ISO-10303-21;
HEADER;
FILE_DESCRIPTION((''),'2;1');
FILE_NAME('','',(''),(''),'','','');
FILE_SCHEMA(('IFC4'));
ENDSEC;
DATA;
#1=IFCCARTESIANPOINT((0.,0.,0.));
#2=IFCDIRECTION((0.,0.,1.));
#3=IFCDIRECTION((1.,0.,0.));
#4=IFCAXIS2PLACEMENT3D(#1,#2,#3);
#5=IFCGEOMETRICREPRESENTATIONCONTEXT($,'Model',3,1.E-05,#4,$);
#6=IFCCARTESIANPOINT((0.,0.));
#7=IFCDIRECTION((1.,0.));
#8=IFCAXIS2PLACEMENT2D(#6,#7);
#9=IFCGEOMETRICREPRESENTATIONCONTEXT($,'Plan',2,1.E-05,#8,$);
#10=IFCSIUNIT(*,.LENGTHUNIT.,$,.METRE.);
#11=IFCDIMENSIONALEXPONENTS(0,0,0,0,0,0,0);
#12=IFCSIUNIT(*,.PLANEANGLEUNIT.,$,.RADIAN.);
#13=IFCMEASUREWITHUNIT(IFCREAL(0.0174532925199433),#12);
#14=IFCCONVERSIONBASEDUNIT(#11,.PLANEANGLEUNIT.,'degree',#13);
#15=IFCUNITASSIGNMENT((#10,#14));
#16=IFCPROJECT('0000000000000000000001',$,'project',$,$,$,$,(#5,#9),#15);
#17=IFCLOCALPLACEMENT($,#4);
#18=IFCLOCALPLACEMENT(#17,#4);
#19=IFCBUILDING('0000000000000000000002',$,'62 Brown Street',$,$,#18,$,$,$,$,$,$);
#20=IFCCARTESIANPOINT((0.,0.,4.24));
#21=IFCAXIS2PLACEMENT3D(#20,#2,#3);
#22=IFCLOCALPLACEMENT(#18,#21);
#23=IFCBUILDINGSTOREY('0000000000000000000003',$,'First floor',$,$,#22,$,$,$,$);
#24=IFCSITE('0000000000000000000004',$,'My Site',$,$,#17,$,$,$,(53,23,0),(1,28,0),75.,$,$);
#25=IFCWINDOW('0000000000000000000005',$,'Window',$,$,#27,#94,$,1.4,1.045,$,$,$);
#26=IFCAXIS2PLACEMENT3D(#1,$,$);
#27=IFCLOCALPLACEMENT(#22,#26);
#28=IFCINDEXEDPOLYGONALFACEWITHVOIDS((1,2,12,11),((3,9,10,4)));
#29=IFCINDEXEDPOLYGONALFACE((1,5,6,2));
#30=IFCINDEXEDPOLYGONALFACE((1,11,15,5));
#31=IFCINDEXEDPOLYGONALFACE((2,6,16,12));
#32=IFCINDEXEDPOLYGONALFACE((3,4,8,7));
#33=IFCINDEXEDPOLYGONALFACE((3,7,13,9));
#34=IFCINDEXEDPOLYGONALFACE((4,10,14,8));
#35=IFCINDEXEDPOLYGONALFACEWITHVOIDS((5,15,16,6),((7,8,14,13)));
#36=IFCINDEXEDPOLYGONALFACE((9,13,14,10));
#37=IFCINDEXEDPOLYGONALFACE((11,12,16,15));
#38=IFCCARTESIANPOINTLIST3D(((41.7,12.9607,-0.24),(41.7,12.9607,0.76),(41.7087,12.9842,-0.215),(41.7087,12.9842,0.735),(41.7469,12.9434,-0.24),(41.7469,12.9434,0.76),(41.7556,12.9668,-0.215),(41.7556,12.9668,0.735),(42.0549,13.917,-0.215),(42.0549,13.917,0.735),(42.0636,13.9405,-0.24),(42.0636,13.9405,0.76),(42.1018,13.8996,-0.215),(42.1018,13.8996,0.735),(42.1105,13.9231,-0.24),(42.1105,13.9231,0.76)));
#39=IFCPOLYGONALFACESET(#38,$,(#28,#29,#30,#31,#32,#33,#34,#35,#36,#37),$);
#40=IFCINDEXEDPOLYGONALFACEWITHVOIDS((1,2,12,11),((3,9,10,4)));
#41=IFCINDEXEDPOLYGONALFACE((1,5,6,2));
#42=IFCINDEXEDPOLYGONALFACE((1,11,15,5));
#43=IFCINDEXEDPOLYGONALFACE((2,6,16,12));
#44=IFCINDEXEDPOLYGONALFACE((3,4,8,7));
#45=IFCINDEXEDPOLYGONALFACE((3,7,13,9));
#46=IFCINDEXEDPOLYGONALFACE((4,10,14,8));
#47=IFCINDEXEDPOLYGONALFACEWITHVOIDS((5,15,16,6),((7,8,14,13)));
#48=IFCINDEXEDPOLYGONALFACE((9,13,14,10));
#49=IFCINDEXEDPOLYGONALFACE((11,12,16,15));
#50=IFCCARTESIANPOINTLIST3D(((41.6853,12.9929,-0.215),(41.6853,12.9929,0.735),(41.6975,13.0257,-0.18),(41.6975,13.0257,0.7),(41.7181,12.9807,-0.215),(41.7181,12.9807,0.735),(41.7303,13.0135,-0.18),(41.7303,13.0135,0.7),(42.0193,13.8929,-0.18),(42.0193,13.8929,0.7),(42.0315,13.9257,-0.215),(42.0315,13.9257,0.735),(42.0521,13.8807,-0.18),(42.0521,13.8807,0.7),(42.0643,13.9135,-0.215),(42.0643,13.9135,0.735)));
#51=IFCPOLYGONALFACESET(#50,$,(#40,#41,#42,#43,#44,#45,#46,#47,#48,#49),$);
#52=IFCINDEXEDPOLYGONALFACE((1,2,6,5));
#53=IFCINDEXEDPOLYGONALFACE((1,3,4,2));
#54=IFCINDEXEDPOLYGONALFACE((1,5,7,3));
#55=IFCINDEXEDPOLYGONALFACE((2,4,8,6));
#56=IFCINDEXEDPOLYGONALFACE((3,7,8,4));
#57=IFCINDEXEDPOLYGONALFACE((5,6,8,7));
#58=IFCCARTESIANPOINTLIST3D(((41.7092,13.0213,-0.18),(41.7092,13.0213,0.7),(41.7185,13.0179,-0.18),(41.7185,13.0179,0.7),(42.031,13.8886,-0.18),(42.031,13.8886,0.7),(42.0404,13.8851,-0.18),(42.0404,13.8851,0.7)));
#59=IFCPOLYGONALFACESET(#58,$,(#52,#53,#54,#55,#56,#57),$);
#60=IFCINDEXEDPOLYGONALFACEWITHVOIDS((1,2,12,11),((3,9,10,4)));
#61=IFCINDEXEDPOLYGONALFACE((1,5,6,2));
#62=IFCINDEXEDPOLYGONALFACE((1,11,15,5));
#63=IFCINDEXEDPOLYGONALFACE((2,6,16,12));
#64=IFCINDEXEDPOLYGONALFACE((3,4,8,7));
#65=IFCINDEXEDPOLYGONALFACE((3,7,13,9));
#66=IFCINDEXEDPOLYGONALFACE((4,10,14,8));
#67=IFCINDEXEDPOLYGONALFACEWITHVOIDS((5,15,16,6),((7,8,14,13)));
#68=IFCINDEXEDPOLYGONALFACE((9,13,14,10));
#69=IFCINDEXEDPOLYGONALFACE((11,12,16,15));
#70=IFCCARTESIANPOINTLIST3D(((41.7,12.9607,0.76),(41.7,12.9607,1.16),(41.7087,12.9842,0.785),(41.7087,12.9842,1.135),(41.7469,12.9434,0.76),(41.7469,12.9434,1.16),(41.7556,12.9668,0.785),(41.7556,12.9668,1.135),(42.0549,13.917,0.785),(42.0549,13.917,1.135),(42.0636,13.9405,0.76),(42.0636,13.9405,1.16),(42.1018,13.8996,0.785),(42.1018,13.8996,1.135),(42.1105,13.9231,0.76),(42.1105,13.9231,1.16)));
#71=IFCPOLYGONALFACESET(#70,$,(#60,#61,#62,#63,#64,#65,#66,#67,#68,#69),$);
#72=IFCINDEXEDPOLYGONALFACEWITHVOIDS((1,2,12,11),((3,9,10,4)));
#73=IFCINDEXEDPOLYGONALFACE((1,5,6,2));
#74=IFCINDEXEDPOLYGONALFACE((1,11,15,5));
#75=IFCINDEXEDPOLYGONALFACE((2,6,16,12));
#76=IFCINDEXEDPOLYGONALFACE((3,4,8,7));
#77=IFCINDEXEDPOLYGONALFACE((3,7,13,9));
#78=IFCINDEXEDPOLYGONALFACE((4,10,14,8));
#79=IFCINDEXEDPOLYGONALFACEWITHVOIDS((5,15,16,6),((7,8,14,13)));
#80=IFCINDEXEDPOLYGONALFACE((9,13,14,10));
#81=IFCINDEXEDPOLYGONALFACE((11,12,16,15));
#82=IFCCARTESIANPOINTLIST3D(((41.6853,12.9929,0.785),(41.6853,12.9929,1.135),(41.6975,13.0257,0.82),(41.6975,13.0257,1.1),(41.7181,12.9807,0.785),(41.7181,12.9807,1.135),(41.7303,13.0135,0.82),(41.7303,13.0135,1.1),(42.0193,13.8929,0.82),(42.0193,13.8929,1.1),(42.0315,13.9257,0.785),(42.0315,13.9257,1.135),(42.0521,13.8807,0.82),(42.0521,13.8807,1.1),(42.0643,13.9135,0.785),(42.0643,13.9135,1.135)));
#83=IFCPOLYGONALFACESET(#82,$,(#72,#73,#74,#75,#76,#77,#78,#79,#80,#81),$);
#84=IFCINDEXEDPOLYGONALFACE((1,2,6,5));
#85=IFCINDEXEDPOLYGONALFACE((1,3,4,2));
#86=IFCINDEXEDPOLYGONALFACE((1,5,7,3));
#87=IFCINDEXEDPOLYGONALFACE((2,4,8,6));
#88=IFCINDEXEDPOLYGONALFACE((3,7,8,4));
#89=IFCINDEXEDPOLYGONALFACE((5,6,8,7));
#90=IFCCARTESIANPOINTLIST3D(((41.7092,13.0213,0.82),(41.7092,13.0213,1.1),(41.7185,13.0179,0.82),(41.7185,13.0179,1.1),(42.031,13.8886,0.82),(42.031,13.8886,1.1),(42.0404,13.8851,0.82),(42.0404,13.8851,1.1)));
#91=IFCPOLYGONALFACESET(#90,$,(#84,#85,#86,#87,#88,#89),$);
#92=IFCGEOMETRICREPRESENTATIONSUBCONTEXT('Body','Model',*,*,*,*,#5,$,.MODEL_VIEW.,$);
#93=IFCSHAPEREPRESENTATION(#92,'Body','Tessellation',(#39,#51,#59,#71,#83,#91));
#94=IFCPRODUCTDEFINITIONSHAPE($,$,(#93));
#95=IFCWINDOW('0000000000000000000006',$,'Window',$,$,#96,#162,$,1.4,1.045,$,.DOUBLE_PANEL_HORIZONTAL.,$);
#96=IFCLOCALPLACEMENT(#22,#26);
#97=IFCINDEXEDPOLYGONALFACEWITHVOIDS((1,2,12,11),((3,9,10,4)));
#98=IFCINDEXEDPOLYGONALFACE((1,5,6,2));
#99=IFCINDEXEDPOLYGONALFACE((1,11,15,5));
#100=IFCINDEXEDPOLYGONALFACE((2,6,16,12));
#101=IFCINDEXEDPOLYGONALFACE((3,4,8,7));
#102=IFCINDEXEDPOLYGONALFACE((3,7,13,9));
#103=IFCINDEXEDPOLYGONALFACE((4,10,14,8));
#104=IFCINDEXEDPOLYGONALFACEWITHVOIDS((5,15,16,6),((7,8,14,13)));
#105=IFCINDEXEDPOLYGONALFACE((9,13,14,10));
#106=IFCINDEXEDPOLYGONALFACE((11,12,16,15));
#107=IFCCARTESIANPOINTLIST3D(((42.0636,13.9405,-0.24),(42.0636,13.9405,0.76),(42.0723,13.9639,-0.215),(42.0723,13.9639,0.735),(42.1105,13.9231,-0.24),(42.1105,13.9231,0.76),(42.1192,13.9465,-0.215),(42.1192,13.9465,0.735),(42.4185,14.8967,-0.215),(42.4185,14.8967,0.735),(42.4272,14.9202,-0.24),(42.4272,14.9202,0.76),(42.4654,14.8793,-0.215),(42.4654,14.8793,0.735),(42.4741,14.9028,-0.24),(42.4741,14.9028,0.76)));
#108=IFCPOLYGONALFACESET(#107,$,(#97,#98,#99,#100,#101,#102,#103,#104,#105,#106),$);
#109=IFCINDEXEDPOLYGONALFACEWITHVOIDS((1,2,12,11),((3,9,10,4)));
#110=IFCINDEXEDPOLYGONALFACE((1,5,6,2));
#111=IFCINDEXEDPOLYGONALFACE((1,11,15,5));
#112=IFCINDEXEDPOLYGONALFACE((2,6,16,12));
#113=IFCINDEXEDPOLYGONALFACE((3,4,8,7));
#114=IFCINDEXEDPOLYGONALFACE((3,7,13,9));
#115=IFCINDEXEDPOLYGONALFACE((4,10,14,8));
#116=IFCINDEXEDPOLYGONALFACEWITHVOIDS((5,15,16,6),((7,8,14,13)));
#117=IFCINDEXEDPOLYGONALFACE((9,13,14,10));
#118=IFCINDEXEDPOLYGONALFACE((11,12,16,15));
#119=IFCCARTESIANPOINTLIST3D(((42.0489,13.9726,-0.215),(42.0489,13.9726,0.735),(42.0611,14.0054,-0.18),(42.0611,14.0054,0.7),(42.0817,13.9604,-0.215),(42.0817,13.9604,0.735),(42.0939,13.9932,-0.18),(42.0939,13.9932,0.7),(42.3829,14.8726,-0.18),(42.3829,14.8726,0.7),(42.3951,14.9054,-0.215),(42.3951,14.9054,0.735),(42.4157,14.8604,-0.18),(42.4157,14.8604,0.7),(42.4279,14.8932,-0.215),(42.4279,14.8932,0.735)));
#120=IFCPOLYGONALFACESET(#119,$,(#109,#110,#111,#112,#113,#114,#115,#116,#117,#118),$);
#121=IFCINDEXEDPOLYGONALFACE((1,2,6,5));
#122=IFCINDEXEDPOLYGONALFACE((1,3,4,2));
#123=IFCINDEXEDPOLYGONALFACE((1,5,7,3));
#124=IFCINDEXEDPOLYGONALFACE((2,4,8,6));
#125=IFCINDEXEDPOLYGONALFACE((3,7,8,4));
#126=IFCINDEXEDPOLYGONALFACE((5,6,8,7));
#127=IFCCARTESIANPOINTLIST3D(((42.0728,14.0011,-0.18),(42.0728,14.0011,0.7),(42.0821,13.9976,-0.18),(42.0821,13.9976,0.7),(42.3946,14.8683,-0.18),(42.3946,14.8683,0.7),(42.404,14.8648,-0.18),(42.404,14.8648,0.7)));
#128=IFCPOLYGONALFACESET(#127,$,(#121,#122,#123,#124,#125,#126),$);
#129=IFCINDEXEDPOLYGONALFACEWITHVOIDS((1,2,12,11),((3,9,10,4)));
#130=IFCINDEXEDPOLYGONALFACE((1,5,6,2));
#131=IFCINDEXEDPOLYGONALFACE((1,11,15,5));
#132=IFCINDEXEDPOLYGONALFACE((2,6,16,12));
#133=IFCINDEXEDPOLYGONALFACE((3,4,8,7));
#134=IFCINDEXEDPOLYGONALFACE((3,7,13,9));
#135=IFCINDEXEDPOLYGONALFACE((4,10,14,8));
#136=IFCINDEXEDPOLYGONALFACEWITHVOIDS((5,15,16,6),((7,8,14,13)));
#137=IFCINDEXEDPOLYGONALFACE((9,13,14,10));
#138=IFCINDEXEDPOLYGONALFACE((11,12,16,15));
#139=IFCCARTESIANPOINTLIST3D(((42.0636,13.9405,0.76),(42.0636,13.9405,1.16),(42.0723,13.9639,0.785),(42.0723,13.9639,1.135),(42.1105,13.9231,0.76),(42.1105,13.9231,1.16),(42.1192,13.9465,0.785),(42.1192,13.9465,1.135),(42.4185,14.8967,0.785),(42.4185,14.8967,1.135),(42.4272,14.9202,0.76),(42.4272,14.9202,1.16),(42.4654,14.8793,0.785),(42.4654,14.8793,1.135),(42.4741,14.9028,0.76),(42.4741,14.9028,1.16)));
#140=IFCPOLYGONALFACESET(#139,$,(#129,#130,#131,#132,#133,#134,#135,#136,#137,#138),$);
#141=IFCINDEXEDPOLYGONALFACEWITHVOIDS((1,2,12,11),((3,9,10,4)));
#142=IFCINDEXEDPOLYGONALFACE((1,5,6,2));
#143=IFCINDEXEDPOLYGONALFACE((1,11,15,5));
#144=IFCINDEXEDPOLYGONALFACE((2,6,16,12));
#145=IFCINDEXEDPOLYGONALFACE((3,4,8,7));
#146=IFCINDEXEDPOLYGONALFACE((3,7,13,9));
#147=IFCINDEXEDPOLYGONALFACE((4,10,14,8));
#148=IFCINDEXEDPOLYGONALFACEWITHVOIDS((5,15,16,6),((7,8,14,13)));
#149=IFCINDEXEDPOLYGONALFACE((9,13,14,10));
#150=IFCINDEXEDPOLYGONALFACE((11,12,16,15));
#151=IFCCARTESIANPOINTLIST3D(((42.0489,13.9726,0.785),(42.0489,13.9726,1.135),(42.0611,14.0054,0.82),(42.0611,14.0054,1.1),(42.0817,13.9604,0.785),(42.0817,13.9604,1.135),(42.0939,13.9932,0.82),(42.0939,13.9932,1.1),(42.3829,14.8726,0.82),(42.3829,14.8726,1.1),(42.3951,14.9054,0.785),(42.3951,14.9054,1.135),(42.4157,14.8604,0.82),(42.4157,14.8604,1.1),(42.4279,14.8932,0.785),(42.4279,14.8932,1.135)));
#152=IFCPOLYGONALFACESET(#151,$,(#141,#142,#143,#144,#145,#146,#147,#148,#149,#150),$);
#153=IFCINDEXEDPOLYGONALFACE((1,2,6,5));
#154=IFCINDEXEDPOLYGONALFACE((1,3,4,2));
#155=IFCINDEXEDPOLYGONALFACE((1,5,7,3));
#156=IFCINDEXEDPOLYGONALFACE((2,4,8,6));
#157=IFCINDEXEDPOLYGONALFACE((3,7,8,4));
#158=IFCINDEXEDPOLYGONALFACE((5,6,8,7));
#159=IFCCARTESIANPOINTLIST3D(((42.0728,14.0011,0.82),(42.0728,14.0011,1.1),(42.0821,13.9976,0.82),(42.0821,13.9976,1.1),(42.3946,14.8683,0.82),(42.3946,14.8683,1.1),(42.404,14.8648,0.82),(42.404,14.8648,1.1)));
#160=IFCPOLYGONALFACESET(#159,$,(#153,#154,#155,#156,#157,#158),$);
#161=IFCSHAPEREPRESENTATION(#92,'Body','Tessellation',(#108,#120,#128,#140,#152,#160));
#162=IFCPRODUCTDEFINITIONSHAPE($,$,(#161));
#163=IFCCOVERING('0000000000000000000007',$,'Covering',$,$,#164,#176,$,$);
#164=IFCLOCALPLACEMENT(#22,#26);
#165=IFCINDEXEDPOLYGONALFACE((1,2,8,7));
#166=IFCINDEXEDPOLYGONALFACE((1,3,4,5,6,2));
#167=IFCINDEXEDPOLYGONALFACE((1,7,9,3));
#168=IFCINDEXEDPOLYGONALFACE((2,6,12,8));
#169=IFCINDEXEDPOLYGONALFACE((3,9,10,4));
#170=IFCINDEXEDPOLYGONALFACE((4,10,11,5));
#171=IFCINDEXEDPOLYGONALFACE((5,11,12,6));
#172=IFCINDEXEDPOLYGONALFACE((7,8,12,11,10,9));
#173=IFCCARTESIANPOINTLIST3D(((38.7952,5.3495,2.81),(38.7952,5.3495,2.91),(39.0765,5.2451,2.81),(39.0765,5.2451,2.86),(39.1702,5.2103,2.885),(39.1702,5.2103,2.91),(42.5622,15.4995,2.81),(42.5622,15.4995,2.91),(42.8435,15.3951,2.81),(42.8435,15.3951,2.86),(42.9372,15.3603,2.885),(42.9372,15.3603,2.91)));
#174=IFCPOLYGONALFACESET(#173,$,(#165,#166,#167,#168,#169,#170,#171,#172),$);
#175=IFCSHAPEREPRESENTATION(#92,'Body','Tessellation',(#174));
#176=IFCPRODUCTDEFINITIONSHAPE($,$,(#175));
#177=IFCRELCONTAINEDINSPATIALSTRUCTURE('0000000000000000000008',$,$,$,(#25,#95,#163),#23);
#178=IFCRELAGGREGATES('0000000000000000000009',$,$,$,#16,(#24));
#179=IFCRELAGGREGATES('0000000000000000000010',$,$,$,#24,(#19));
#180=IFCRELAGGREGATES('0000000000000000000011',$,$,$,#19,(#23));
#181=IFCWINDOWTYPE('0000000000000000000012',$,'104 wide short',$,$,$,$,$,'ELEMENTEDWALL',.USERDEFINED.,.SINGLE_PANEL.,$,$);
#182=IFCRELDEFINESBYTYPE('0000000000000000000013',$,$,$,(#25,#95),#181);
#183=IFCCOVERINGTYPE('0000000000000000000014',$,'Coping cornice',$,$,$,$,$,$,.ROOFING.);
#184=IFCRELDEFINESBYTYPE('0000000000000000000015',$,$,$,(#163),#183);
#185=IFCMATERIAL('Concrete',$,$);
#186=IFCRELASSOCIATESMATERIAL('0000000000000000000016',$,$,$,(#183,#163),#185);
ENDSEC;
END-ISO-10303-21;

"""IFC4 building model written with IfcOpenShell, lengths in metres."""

from ifc_helpers import new_model, entity, si_unit, converted_unit, frame, origin_with_axes, origin_2d_with_axis, place, context, subcontext, project, spatial, line, indexed_curve, outline, extrude, shape, source, transform, mapped, material, material_profile, profile_set, profile_usage, type_object, type_shapes, element, save


model = new_model("IFC4")

# Units and contexts
model_context = context("Model", 3, precision=1e-05, world=origin_with_axes())
plan_context = context("Plan", 2, precision=1e-05, world=origin_2d_with_axis())
body_context_1 = subcontext(model_context, "Body", "Model", "MODEL_VIEW")
body_context_2 = subcontext(plan_context, "Body", "Plan", "PLAN_VIEW")
ifc_project = project(units=[si_unit("LENGTHUNIT", "METRE"), converted_unit("PLANEANGLEUNIT", "degree", entity("IfcReal", 0.0174532925199433), si_unit("PLANEANGLEUNIT", "RADIAN"), dimensions=[0, 0, 0, 0, 0, 0, 0])], contexts=[model_context, plan_context])

# Site, building, storey
site_placement = place(None, origin_with_axes())
site = spatial("IfcSite", under=ifc_project, at=site_placement, Name="My Site", RefLatitude=(53, 23, 0), RefLongitude=(1, 28, 0), RefElevation=75.0)
building_placement = place(site_placement, origin_with_axes())
building = spatial("IfcBuilding", under=site, at=building_placement, Name="62 Brown Street")
storey_placement = place(building_placement, frame((0.0, 0.0, 4.24), z_axis=(0.0, 0.0, 1.0), x_axis=(1.0, 0.0, 0.0)))
storey = spatial("IfcBuildingStorey", under=building, at=storey_placement, Name="First floor")

# Shared definitions
window_type_1 = type_object("IfcWindowType", Name="104 wide short", ElementType="ELEMENTEDWALL", PartitioningType="SINGLE_PANEL", PredefinedType="USERDEFINED")
shared_shape_1 = source(origin_with_axes(), body_context_1, "Body", "SweptSolid", [
    extrude(outline(indexed_curve([(0.0, 0.0), (1.045, 0.0), (1.045, 1.0), (0.0, 1.0)], segments=[line(1, 2, 3, 4, 1)]), holes=[indexed_curve([(0.025, 0.025), (1.02, 0.025), (1.02, 0.975), (0.025, 0.975)], segments=[line(1, 2, 3, 4, 1)])]), frame((0.0, 0.15, 0.0), z_axis=(0.0, -1.0, 0.0), x_axis=(1.0, 0.0, 0.0)), (0.0, 0.0, -1.0), 0.05),
    extrude(outline(indexed_curve([(0.0, 0.0), (0.995, 0.0), (0.995, 0.95), (0.0, 0.95)], segments=[line(1, 2, 3, 4, 1)]), holes=[indexed_curve([(0.035, 0.035), (0.96, 0.035), (0.96, 0.915), (0.035, 0.915)], segments=[line(1, 2, 3, 4, 1)])]), frame((0.025, 0.19, 0.025), z_axis=(0.0, -1.0, 0.0), x_axis=(1.0, 0.0, 0.0)), (0.0, 0.0, -1.0), 0.035),
    extrude(outline(indexed_curve([(0.035, 0.035), (0.96, 0.035), (0.96, 0.915), (0.035, 0.915)], segments=[line(1, 2, 3, 4, 1)])), frame((0.025, 0.2025, 0.025), z_axis=(0.0, -1.0, 0.0), x_axis=(1.0, 0.0, 0.0)), (0.0, 0.0, -1.0), 0.01),
    extrude(outline(indexed_curve([(0.0, 0.0), (1.045, 0.0), (1.045, 0.4), (0.0, 0.4)], segments=[line(1, 2, 3, 4, 1)]), holes=[indexed_curve([(0.025, 0.025), (1.02, 0.025), (1.02, 0.375), (0.025, 0.375)], segments=[line(1, 2, 3, 4, 1)])]), frame((0.0, 0.15, 1.0), z_axis=(0.0, -1.0, 0.0), x_axis=(1.0, 0.0, 0.0)), (0.0, 0.0, -1.0), 0.05),
    extrude(outline(indexed_curve([(0.0, 0.0), (0.995, 0.0), (0.995, 0.35), (0.0, 0.35)], segments=[line(1, 2, 3, 4, 1)]), holes=[indexed_curve([(0.035, 0.035), (0.96, 0.035), (0.96, 0.315), (0.035, 0.315)], segments=[line(1, 2, 3, 4, 1)])]), frame((0.025, 0.19, 1.025), z_axis=(0.0, -1.0, 0.0), x_axis=(1.0, 0.0, 0.0)), (0.0, 0.0, -1.0), 0.035),
    extrude(outline(indexed_curve([(0.035, 0.035), (0.96, 0.035), (0.96, 0.315), (0.035, 0.315)], segments=[line(1, 2, 3, 4, 1)])), frame((0.025, 0.2025, 1.025), z_axis=(0.0, -1.0, 0.0), x_axis=(1.0, 0.0, 0.0)), (0.0, 0.0, -1.0), 0.01),
])
shared_shape_2 = source(origin_with_axes(), body_context_2, "Body", "Curve2D", [
    entity("IfcIndexedPolyCurve", entity("IfcCartesianPointList2D", [[0.025, 0.15], [1.02, 0.15]])),
    entity("IfcIndexedPolyCurve", entity("IfcCartesianPointList2D", [[0.0, 0.2], [0.025, 0.2], [0.025, 0.15], [0.0, 0.15]]), [entity("IfcLineIndex", [1, 2, 3, 4, 1])]),
    entity("IfcIndexedPolyCurve", entity("IfcCartesianPointList2D", [[1.045, 0.2], [1.02, 0.2], [1.02, 0.15], [1.045, 0.15]]), [entity("IfcLineIndex", [1, 2, 3, 4, 1])]),
    entity("IfcIndexedPolyCurve", entity("IfcCartesianPointList2D", [[0.025, 0.19], [0.06, 0.19], [0.06, 0.225], [0.025, 0.225]]), [entity("IfcLineIndex", [1, 2, 3, 4, 1])]),
    entity("IfcIndexedPolyCurve", entity("IfcCartesianPointList2D", [[1.02, 0.19], [0.985, 0.19], [0.985, 0.225], [1.02, 0.225]]), [entity("IfcLineIndex", [1, 2, 3, 4, 1])]),
    entity("IfcIndexedPolyCurve", entity("IfcCartesianPointList2D", [[0.06, 0.19], [0.985, 0.19]])),
    entity("IfcIndexedPolyCurve", entity("IfcCartesianPointList2D", [[0.06, 0.225], [0.985, 0.225]])),
    entity("IfcIndexedPolyCurve", entity("IfcCartesianPointList2D", [[0.06, 0.2075], [0.985, 0.2075]])),
])
type_shapes(window_type_1, [shared_shape_1, shared_shape_2])

# Windows
for number, where, z_axis, x_axis, name in (
    (1, (41.8875, 12.8912, -0.24), (0.0, 0.0, 1.0), (0.347944, 0.937515, 0.0), "Window"),
):
    element("IfcWindow", number, at=place(storey_placement, frame(where, z_axis=z_axis, x_axis=x_axis)), inside=storey, type_object=window_type_1, Name=name, OverallHeight=1.4, OverallWidth=1.045, shapes=[
        shape(body_context_1, "Body", "MappedRepresentation", [mapped(shared_shape_1, transform((0.0, 0.0, 0.0), x_axis=(1.0, 0.0, 0.0), y_axis=(0.0, 1.0, 0.0), z_axis=(0.0, 0.0, 1.0), scale=1.0))]),
        shape(body_context_2, "Body", "MappedRepresentation", [mapped(shared_shape_2, transform((0.0, 0.0, 0.0), x_axis=(1.0, 0.0, 0.0), y_axis=(0.0, 1.0, 0.0), z_axis=(0.0, 0.0, 1.0), scale=1.0))]),
    ])
window_1_placement = place(storey_placement, frame((42.2511, 13.8709, -0.24), z_axis=(0.0, 0.0, 1.0), x_axis=(0.347944, 0.937515, 0.0)))
element("IfcWindow", 2, at=window_1_placement, inside=storey, type_object=window_type_1, Name="Window", OverallHeight=1.4, OverallWidth=1.045, PartitioningType="DOUBLE_PANEL_HORIZONTAL", shapes=[
    shape(body_context_1, "Body", "MappedRepresentation", [mapped(shared_shape_1, transform((0.0, 0.0, 0.0), x_axis=(1.0, 0.0, 0.0), y_axis=(0.0, 1.0, 0.0), z_axis=(0.0, 0.0, 1.0), scale=1.0))]),
    shape(body_context_2, "Body", "MappedRepresentation", [mapped(shared_shape_2, transform((0.0, 0.0, 0.0), x_axis=(1.0, 0.0, 0.0), y_axis=(0.0, 1.0, 0.0), z_axis=(0.0, 0.0, 1.0), scale=1.0))]),
])

# Covering
ifc_material_1 = material(Name="Concrete")
ifc_material_profile = material_profile(ifc_material_1, outline(indexed_curve([(-0.2, 0.1), (0.2, 0.1), (0.2, 0.075), (0.1, 0.05), (0.1, 0.0), (-0.2, 0.0)], segments=[line(5, 4), line(4, 3), line(3, 2), line(2, 1), line(1, 6), line(6, 5)], self_intersect=False)))
ifc_profile_set = profile_set([ifc_material_profile], Name="cornice")
ifc_profile_usage = profile_usage(ifc_profile_set, cardinal=5)
covering_type = type_object("IfcCoveringType", Name="Coping cornice", PredefinedType="ROOFING", material=ifc_profile_set)
covering_placement = place(storey_placement, frame((42.7497, 15.4299, 2.81), z_axis=(-0.347944, -0.937515, 0.0), x_axis=(0.937515, -0.347944, 0.0)))
element("IfcCovering", 3, at=covering_placement, inside=storey, type_object=covering_type, material=ifc_profile_usage, Name="Covering", context=body_context_1, shape_type="SweptSolid", body=[
    extrude(outline(indexed_curve([(-0.2, 0.1), (0.2, 0.1), (0.2, 0.075), (0.1, 0.05), (0.1, 0.0), (-0.2, 0.0)], segments=[line(5, 4), line(4, 3), line(3, 2), line(2, 1), line(1, 6), line(6, 5)], self_intersect=False)), origin_with_axes(), (0.0, 0.0, 1.0), 10.8265),
])

save(model, "model.ifc")
